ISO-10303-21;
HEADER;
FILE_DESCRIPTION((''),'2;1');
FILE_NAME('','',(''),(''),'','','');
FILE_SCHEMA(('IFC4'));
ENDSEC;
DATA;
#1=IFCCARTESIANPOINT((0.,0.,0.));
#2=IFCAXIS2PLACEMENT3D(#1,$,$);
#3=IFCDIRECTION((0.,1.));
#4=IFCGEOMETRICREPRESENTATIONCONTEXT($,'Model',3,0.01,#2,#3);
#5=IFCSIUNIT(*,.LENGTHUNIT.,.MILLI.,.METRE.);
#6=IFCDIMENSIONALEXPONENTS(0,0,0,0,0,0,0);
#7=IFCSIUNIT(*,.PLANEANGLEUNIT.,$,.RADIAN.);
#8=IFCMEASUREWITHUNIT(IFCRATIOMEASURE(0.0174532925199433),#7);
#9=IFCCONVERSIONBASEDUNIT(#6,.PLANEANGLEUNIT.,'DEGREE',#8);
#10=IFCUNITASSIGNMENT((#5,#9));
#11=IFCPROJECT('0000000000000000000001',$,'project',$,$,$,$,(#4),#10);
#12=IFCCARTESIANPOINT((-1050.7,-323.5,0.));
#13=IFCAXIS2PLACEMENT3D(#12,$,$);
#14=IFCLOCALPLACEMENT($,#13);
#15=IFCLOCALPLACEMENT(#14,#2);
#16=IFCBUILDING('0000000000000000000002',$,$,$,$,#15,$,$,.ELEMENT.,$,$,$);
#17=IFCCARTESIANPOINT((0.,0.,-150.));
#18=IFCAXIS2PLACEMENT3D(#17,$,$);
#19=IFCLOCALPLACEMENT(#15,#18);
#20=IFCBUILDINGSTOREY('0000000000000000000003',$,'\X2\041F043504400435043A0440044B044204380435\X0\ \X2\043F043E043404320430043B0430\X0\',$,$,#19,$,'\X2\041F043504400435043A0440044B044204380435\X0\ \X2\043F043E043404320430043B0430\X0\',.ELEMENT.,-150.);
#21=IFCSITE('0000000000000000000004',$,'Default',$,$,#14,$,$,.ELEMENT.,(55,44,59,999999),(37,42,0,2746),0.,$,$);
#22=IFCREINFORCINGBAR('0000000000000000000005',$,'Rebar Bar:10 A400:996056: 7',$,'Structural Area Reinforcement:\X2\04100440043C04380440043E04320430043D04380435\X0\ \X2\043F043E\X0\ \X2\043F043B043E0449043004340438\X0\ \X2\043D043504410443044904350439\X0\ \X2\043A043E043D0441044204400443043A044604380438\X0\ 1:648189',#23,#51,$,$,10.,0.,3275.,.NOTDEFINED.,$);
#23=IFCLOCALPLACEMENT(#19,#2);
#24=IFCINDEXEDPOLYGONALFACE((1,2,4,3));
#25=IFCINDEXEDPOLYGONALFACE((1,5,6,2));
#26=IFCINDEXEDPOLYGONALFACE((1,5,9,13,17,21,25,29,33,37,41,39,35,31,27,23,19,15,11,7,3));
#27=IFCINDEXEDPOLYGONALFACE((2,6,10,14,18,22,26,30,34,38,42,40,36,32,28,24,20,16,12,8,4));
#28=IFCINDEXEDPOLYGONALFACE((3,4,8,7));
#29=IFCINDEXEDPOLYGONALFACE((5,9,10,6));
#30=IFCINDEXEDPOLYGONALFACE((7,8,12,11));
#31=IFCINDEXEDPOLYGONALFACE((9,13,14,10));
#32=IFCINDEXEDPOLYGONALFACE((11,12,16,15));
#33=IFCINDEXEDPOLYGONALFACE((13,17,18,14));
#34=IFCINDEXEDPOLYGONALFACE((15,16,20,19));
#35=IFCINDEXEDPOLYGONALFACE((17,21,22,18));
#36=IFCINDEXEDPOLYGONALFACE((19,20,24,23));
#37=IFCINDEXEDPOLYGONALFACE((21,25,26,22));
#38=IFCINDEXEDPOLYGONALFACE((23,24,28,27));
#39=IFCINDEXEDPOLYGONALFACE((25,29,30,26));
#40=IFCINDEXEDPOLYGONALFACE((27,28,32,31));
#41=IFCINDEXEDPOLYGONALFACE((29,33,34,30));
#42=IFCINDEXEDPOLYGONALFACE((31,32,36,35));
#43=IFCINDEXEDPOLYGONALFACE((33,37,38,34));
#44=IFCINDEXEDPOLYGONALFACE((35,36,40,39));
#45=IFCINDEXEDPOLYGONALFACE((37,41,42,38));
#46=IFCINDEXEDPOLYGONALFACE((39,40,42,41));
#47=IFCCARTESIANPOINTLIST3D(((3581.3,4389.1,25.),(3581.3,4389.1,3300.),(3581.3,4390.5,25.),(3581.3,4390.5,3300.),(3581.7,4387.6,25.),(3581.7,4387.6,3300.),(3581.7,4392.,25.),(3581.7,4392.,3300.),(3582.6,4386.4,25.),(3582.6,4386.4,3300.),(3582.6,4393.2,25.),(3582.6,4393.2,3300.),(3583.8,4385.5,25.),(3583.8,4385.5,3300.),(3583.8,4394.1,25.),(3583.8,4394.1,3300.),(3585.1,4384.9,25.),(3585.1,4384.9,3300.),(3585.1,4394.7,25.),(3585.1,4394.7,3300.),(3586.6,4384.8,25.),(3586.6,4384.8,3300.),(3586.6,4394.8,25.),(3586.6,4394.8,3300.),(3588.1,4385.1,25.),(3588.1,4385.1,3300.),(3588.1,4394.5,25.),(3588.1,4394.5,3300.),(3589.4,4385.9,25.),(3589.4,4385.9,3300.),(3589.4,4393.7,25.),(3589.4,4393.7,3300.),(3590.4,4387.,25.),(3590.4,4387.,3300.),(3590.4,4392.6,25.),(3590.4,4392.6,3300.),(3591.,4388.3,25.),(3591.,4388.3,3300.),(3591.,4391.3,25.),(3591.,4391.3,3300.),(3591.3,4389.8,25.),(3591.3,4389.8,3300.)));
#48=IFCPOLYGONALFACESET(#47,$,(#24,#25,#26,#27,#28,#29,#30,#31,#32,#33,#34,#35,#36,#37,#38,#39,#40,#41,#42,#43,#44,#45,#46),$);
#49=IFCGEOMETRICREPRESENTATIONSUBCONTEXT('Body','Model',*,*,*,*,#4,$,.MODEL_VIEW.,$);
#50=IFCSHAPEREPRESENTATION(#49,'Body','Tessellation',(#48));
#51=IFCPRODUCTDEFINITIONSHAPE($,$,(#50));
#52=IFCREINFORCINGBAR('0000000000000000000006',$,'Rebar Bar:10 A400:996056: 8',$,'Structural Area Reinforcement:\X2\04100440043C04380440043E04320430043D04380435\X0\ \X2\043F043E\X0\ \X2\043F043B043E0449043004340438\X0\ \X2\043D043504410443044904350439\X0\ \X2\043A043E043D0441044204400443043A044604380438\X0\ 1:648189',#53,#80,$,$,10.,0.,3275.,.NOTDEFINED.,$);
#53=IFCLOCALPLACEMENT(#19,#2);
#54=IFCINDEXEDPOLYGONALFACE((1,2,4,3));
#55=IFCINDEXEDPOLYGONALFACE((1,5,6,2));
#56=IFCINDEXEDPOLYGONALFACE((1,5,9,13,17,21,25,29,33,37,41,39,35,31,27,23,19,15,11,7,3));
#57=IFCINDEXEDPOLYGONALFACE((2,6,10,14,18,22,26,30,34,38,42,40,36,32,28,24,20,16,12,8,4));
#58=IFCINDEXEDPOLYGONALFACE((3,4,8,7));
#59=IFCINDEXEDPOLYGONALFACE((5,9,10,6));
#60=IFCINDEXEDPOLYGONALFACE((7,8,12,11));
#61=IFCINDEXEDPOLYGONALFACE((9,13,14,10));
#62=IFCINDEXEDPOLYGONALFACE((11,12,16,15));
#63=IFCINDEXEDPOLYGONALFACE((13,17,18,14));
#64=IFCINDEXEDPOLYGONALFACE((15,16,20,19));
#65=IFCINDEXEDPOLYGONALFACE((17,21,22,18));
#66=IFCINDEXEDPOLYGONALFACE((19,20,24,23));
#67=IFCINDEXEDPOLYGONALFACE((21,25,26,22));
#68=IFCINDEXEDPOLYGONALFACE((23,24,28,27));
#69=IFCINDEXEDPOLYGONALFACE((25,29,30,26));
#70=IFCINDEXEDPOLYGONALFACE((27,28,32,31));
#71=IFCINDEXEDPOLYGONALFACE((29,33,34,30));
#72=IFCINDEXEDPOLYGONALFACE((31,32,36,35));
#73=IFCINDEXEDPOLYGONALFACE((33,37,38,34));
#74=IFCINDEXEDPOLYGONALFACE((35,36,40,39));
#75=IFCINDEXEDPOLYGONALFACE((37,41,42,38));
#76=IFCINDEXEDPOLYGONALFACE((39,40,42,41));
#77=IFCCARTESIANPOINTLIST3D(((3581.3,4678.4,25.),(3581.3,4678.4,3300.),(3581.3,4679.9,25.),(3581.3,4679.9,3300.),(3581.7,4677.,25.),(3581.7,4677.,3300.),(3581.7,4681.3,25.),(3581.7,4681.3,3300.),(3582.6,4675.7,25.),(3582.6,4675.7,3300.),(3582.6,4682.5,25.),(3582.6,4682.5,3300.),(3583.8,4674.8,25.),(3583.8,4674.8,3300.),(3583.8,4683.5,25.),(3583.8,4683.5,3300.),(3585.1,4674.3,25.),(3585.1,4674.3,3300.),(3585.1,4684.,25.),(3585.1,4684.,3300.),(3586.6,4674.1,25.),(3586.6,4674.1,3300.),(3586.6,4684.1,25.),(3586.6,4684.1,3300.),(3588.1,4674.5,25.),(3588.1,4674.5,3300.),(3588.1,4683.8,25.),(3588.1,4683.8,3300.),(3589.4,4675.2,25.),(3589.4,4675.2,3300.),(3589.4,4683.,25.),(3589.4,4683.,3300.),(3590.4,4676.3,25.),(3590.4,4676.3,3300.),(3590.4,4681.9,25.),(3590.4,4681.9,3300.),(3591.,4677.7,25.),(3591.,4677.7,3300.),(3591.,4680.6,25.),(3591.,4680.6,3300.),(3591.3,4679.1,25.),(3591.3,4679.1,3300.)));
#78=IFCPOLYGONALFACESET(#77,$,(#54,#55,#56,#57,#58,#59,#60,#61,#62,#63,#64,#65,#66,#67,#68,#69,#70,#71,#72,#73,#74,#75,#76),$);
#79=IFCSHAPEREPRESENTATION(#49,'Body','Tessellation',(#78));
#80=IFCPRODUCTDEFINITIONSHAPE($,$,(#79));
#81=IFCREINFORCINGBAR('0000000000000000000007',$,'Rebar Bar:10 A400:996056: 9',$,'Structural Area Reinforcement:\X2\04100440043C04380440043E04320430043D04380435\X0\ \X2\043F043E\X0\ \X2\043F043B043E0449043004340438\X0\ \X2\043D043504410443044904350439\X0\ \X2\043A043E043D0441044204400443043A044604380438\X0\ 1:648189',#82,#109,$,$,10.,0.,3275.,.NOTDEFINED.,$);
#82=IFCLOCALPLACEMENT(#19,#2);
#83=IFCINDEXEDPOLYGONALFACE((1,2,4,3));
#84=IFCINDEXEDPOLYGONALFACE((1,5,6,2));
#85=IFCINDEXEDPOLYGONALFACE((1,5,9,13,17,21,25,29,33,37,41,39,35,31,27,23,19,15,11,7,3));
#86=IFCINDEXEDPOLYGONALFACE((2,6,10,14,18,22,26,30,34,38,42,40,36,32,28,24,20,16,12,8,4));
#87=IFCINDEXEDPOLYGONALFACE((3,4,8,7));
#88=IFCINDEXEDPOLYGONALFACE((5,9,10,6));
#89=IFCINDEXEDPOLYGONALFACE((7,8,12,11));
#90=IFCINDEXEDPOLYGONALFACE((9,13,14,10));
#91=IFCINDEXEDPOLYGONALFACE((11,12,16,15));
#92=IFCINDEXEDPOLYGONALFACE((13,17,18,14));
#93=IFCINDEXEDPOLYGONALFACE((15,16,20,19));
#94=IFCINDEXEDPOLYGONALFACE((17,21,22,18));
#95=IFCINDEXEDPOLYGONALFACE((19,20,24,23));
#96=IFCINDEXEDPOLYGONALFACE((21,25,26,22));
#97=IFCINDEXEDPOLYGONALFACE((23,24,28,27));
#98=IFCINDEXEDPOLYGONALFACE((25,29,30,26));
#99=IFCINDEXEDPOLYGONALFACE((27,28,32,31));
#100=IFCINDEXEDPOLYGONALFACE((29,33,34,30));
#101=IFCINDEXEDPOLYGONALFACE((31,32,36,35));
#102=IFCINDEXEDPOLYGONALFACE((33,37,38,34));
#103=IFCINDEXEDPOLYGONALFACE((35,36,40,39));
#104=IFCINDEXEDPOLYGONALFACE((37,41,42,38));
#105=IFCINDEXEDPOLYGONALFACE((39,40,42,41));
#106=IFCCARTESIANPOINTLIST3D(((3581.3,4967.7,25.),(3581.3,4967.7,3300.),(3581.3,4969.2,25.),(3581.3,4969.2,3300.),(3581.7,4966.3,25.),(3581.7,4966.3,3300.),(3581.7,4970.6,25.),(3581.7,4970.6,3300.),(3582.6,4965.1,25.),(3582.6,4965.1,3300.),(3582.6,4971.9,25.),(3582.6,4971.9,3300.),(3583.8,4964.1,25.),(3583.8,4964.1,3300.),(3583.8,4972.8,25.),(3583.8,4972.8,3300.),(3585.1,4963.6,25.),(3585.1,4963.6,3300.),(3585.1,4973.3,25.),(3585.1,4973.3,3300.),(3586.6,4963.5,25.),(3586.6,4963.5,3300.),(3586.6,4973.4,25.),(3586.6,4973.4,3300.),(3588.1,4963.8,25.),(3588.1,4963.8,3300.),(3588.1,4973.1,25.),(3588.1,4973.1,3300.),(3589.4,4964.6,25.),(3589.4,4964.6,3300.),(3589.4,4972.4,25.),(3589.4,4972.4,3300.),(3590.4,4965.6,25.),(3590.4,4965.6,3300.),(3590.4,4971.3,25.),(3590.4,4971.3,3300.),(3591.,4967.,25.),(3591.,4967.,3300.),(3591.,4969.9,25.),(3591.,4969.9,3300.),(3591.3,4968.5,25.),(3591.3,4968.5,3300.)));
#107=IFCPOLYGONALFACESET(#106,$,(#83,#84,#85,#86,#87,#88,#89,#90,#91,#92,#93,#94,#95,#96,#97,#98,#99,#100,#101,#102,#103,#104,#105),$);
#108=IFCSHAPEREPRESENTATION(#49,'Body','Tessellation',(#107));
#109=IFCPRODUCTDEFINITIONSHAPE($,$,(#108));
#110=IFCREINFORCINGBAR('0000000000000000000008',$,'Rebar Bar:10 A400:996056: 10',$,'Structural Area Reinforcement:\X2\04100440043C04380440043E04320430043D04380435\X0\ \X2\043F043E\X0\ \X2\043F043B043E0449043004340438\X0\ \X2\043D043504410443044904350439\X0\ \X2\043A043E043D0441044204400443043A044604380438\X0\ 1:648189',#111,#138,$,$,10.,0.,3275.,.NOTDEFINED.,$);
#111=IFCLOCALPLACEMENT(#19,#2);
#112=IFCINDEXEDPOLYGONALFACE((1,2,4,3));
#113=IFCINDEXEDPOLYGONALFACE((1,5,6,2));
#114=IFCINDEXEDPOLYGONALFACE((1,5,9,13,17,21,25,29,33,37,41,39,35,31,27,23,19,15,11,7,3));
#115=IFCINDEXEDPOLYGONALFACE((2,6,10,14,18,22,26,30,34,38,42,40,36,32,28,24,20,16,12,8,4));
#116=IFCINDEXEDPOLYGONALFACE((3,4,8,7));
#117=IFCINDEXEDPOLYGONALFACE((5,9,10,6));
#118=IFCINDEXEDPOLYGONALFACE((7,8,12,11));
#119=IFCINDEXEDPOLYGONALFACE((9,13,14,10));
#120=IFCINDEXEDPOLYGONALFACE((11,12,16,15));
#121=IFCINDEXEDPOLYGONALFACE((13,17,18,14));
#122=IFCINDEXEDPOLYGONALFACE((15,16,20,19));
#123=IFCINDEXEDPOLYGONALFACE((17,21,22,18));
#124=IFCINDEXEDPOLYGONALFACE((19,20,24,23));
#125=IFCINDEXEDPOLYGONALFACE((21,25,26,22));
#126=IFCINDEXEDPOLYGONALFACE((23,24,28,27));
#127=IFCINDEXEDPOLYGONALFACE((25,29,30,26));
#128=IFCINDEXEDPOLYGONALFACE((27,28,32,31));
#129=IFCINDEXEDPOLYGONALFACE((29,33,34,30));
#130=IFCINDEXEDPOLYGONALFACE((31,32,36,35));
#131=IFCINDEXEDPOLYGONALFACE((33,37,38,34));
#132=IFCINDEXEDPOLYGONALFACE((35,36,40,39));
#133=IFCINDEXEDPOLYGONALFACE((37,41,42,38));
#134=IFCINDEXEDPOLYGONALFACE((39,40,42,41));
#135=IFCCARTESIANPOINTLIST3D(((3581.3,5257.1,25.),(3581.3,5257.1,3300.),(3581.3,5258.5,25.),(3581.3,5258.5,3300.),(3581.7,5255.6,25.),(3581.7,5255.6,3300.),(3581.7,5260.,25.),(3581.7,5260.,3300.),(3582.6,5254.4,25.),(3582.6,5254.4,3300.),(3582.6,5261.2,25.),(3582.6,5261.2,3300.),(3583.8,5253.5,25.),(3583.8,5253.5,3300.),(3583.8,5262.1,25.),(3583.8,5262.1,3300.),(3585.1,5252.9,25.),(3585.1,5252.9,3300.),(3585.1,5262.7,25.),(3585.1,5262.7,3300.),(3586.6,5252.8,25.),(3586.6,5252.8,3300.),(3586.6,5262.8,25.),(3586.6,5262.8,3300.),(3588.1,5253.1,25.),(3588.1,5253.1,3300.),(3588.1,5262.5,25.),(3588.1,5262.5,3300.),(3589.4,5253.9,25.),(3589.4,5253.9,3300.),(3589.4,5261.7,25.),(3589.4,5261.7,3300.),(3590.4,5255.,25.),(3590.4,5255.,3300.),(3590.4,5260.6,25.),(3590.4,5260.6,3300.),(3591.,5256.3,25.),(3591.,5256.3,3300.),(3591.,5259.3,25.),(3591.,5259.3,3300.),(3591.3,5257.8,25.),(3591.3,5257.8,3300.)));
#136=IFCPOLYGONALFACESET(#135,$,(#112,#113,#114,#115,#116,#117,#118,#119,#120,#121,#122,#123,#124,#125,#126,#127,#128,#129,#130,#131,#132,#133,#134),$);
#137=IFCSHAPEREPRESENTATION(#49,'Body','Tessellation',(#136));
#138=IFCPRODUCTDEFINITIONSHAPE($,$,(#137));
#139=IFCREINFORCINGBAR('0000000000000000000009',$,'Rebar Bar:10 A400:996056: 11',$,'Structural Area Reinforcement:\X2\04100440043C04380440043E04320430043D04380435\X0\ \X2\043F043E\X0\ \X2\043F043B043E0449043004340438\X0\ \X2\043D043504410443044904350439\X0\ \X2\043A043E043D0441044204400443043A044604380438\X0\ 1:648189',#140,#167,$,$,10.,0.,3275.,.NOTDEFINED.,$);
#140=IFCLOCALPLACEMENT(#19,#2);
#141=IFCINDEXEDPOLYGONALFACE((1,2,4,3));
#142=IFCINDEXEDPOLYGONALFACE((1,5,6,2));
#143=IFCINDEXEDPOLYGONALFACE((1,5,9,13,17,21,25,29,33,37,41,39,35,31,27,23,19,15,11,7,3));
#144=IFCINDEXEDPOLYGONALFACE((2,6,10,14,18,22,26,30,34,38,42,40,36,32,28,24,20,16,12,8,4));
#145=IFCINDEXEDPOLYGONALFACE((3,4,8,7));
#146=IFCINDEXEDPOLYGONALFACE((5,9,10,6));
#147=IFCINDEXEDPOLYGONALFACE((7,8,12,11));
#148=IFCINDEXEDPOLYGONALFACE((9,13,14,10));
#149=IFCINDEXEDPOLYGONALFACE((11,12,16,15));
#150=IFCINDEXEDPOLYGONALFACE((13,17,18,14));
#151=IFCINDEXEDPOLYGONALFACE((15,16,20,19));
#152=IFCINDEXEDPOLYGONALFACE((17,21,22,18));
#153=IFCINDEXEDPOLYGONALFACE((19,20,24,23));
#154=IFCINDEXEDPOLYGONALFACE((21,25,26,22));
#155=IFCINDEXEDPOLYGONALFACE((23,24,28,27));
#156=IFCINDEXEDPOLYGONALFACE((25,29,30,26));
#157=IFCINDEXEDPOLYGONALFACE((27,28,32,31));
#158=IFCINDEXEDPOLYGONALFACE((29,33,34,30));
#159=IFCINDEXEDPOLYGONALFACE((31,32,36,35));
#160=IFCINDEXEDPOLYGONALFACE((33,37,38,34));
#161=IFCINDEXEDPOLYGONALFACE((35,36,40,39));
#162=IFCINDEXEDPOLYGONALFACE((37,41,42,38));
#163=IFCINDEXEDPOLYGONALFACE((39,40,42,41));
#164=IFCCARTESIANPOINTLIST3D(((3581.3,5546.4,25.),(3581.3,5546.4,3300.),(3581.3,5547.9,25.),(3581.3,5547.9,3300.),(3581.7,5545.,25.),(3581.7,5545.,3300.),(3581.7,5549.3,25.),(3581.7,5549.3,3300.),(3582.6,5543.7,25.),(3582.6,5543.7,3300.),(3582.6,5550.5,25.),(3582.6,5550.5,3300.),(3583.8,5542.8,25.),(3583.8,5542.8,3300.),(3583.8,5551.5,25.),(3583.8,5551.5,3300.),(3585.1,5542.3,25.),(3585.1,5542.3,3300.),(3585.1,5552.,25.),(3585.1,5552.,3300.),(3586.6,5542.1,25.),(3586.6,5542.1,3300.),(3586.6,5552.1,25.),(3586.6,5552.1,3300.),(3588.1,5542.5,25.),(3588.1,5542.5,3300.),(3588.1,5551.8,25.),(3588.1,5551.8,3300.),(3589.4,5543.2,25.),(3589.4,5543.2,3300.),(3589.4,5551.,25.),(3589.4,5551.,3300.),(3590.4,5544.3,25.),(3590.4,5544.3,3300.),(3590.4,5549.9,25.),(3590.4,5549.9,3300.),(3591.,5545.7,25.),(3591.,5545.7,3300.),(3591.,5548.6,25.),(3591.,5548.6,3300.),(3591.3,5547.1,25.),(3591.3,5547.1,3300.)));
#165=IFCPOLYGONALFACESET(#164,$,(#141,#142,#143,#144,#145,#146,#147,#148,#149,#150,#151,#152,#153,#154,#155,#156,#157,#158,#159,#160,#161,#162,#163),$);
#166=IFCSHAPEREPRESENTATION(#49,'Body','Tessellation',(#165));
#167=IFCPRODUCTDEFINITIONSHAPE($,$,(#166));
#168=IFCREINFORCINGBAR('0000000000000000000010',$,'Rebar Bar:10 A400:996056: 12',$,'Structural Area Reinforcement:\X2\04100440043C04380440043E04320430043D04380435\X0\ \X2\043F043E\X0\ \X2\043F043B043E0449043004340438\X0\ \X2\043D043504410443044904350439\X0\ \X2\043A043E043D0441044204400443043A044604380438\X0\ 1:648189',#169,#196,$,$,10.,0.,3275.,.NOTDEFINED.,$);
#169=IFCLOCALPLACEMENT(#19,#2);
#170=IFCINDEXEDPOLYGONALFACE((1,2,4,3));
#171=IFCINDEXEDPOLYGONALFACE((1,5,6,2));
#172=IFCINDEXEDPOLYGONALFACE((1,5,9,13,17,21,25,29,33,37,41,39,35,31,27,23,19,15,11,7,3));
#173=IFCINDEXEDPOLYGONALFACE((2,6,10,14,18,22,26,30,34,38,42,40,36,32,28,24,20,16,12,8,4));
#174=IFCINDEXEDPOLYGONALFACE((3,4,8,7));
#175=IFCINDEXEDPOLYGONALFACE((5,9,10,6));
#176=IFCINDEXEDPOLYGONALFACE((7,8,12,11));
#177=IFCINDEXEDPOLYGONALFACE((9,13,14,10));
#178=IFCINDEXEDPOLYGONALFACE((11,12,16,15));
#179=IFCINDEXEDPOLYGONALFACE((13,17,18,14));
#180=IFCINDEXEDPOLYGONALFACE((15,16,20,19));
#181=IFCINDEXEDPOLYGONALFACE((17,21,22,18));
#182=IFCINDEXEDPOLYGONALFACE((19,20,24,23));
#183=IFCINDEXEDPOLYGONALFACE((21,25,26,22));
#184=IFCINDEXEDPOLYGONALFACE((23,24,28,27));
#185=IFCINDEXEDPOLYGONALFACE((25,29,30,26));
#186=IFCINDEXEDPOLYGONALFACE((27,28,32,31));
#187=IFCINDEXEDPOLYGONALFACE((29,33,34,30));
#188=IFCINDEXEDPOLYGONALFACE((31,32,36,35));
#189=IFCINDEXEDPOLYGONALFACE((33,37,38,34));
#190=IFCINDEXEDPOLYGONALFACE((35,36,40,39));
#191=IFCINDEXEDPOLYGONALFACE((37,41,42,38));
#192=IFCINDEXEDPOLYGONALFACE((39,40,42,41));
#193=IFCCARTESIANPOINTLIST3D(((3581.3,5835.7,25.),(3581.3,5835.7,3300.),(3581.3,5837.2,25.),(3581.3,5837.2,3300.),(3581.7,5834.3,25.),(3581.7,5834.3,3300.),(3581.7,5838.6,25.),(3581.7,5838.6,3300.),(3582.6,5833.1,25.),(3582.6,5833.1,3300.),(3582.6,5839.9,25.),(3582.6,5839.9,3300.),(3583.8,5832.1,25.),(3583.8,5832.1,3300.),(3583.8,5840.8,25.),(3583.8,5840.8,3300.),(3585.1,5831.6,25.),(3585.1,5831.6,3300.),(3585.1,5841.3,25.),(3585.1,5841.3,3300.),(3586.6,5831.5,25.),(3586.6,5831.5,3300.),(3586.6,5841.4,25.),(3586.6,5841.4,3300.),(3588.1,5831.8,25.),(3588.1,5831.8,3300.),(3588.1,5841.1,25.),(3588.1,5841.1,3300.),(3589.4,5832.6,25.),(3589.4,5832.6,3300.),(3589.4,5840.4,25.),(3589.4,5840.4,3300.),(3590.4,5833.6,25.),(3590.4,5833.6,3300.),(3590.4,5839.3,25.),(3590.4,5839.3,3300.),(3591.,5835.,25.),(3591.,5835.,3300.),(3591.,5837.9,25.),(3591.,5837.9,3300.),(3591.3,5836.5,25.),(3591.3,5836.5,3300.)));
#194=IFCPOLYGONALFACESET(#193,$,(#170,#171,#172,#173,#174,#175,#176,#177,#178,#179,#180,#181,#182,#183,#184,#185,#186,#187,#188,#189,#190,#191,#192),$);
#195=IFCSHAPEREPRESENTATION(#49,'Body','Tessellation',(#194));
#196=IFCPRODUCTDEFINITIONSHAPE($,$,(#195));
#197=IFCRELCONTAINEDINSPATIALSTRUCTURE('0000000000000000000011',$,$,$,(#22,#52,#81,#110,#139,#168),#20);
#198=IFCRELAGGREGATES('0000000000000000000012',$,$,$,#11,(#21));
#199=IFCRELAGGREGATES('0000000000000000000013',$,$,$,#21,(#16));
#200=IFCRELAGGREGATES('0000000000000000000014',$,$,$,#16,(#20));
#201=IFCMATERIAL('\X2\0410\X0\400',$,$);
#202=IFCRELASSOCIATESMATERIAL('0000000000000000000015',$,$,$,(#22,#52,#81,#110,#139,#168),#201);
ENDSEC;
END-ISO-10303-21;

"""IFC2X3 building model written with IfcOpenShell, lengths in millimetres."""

from ifc_helpers import new_model, entity, si_unit, converted_unit, direction, frame, origin, place, context, subcontext, project, spatial, material, element, save


model = new_model("IFC2X3")

# Units and contexts
model_context = context("Model", 3, precision=0.01, world=origin(), true_north=direction((0.0, 1.0)))
body_context = subcontext(model_context, "Body", "Model", "MODEL_VIEW")
ifc_project = project(units=[si_unit("LENGTHUNIT", "METRE", prefix="MILLI"), converted_unit("PLANEANGLEUNIT", "DEGREE", entity("IfcRatioMeasure", 0.0174532925199433), si_unit("PLANEANGLEUNIT", "RADIAN"), dimensions=[0, 0, 0, 0, 0, 0, 0])], contexts=[model_context])

# Site, building, storey
site_placement = place(None, frame((-1050.7, -323.5, 0.0)))
site = spatial("IfcSite", under=ifc_project, at=site_placement, Name="Default", CompositionType="ELEMENT", RefLatitude=(55, 44, 59, 999999), RefLongitude=(37, 42, 0, 2746), RefElevation=0.0)
building_placement = place(site_placement, origin())
building = spatial("IfcBuilding", under=site, at=building_placement, CompositionType="ELEMENT")
storey_placement = place(building_placement, frame((0.0, 0.0, -150.0)))
storey = spatial("IfcBuildingStorey", under=building, at=storey_placement, Name="Перекрытие подвала", LongName="Перекрытие подвала", CompositionType="ELEMENT", Elevation=-150.0)

# Reinforcing bars
ifc_material = material(Name="А400")
reinforcing_bar_1_placement = place(storey_placement, origin())
element("IfcReinforcingBar", 1, at=reinforcing_bar_1_placement, inside=storey, material=ifc_material, Name="Rebar Bar:10 A400:996056: 7", ObjectType="Structural Area Reinforcement:Армирование по площади несущей конструкции 1:648189", BarLength=3275.0, BarRole="NOTDEFINED", CrossSectionArea=0.0, NominalDiameter=10.0, context=body_context, shape_type="AdvancedSweptSolid", body=[
    entity("IfcSweptDiskSolid", entity("IfcCompositeCurve", [entity("IfcCompositeCurveSegment", "CONTINUOUS", True, entity("IfcPolyline", [entity("IfcCartesianPoint", [3586.3, 4389.8, 25.0]), entity("IfcCartesianPoint", [3586.3, 4389.8, 3300.0])]))], False), 5.0, None, 0.0, 1.0),
])
reinforcing_bar_2_placement = place(storey_placement, origin())
element("IfcReinforcingBar", 2, at=reinforcing_bar_2_placement, inside=storey, material=ifc_material, Name="Rebar Bar:10 A400:996056: 8", ObjectType="Structural Area Reinforcement:Армирование по площади несущей конструкции 1:648189", BarLength=3275.0, BarRole="NOTDEFINED", CrossSectionArea=0.0, NominalDiameter=10.0, context=body_context, shape_type="AdvancedSweptSolid", body=[
    entity("IfcSweptDiskSolid", entity("IfcCompositeCurve", [entity("IfcCompositeCurveSegment", "CONTINUOUS", True, entity("IfcPolyline", [entity("IfcCartesianPoint", [3586.3, 4679.1, 25.0]), entity("IfcCartesianPoint", [3586.3, 4679.1, 3300.0])]))], False), 5.0, None, 0.0, 1.0),
])
reinforcing_bar_3_placement = place(storey_placement, origin())
element("IfcReinforcingBar", 3, at=reinforcing_bar_3_placement, inside=storey, material=ifc_material, Name="Rebar Bar:10 A400:996056: 9", ObjectType="Structural Area Reinforcement:Армирование по площади несущей конструкции 1:648189", BarLength=3275.0, BarRole="NOTDEFINED", CrossSectionArea=0.0, NominalDiameter=10.0, context=body_context, shape_type="AdvancedSweptSolid", body=[
    entity("IfcSweptDiskSolid", entity("IfcCompositeCurve", [entity("IfcCompositeCurveSegment", "CONTINUOUS", True, entity("IfcPolyline", [entity("IfcCartesianPoint", [3586.3, 4968.5, 25.0]), entity("IfcCartesianPoint", [3586.3, 4968.5, 3300.0])]))], False), 5.0, None, 0.0, 1.0),
])
reinforcing_bar_4_placement = place(storey_placement, origin())
element("IfcReinforcingBar", 4, at=reinforcing_bar_4_placement, inside=storey, material=ifc_material, Name="Rebar Bar:10 A400:996056: 10", ObjectType="Structural Area Reinforcement:Армирование по площади несущей конструкции 1:648189", BarLength=3275.0, BarRole="NOTDEFINED", CrossSectionArea=0.0, NominalDiameter=10.0, context=body_context, shape_type="AdvancedSweptSolid", body=[
    entity("IfcSweptDiskSolid", entity("IfcCompositeCurve", [entity("IfcCompositeCurveSegment", "CONTINUOUS", True, entity("IfcPolyline", [entity("IfcCartesianPoint", [3586.3, 5257.8, 25.0]), entity("IfcCartesianPoint", [3586.3, 5257.8, 3300.0])]))], False), 5.0, None, 0.0, 1.0),
])
reinforcing_bar_5_placement = place(storey_placement, origin())
element("IfcReinforcingBar", 5, at=reinforcing_bar_5_placement, inside=storey, material=ifc_material, Name="Rebar Bar:10 A400:996056: 11", ObjectType="Structural Area Reinforcement:Армирование по площади несущей конструкции 1:648189", BarLength=3275.0, BarRole="NOTDEFINED", CrossSectionArea=0.0, NominalDiameter=10.0, context=body_context, shape_type="AdvancedSweptSolid", body=[
    entity("IfcSweptDiskSolid", entity("IfcCompositeCurve", [entity("IfcCompositeCurveSegment", "CONTINUOUS", True, entity("IfcPolyline", [entity("IfcCartesianPoint", [3586.3, 5547.1, 25.0]), entity("IfcCartesianPoint", [3586.3, 5547.1, 3300.0])]))], False), 5.0, None, 0.0, 1.0),
])
reinforcing_bar_6_placement = place(storey_placement, origin())
element("IfcReinforcingBar", 6, at=reinforcing_bar_6_placement, inside=storey, material=ifc_material, Name="Rebar Bar:10 A400:996056: 12", ObjectType="Structural Area Reinforcement:Армирование по площади несущей конструкции 1:648189", BarLength=3275.0, BarRole="NOTDEFINED", CrossSectionArea=0.0, NominalDiameter=10.0, context=body_context, shape_type="AdvancedSweptSolid", body=[
    entity("IfcSweptDiskSolid", entity("IfcCompositeCurve", [entity("IfcCompositeCurveSegment", "CONTINUOUS", True, entity("IfcPolyline", [entity("IfcCartesianPoint", [3586.3, 5836.5, 25.0]), entity("IfcCartesianPoint", [3586.3, 5836.5, 3300.0])]))], False), 5.0, None, 0.0, 1.0),
])

save(model, "model.ifc")
